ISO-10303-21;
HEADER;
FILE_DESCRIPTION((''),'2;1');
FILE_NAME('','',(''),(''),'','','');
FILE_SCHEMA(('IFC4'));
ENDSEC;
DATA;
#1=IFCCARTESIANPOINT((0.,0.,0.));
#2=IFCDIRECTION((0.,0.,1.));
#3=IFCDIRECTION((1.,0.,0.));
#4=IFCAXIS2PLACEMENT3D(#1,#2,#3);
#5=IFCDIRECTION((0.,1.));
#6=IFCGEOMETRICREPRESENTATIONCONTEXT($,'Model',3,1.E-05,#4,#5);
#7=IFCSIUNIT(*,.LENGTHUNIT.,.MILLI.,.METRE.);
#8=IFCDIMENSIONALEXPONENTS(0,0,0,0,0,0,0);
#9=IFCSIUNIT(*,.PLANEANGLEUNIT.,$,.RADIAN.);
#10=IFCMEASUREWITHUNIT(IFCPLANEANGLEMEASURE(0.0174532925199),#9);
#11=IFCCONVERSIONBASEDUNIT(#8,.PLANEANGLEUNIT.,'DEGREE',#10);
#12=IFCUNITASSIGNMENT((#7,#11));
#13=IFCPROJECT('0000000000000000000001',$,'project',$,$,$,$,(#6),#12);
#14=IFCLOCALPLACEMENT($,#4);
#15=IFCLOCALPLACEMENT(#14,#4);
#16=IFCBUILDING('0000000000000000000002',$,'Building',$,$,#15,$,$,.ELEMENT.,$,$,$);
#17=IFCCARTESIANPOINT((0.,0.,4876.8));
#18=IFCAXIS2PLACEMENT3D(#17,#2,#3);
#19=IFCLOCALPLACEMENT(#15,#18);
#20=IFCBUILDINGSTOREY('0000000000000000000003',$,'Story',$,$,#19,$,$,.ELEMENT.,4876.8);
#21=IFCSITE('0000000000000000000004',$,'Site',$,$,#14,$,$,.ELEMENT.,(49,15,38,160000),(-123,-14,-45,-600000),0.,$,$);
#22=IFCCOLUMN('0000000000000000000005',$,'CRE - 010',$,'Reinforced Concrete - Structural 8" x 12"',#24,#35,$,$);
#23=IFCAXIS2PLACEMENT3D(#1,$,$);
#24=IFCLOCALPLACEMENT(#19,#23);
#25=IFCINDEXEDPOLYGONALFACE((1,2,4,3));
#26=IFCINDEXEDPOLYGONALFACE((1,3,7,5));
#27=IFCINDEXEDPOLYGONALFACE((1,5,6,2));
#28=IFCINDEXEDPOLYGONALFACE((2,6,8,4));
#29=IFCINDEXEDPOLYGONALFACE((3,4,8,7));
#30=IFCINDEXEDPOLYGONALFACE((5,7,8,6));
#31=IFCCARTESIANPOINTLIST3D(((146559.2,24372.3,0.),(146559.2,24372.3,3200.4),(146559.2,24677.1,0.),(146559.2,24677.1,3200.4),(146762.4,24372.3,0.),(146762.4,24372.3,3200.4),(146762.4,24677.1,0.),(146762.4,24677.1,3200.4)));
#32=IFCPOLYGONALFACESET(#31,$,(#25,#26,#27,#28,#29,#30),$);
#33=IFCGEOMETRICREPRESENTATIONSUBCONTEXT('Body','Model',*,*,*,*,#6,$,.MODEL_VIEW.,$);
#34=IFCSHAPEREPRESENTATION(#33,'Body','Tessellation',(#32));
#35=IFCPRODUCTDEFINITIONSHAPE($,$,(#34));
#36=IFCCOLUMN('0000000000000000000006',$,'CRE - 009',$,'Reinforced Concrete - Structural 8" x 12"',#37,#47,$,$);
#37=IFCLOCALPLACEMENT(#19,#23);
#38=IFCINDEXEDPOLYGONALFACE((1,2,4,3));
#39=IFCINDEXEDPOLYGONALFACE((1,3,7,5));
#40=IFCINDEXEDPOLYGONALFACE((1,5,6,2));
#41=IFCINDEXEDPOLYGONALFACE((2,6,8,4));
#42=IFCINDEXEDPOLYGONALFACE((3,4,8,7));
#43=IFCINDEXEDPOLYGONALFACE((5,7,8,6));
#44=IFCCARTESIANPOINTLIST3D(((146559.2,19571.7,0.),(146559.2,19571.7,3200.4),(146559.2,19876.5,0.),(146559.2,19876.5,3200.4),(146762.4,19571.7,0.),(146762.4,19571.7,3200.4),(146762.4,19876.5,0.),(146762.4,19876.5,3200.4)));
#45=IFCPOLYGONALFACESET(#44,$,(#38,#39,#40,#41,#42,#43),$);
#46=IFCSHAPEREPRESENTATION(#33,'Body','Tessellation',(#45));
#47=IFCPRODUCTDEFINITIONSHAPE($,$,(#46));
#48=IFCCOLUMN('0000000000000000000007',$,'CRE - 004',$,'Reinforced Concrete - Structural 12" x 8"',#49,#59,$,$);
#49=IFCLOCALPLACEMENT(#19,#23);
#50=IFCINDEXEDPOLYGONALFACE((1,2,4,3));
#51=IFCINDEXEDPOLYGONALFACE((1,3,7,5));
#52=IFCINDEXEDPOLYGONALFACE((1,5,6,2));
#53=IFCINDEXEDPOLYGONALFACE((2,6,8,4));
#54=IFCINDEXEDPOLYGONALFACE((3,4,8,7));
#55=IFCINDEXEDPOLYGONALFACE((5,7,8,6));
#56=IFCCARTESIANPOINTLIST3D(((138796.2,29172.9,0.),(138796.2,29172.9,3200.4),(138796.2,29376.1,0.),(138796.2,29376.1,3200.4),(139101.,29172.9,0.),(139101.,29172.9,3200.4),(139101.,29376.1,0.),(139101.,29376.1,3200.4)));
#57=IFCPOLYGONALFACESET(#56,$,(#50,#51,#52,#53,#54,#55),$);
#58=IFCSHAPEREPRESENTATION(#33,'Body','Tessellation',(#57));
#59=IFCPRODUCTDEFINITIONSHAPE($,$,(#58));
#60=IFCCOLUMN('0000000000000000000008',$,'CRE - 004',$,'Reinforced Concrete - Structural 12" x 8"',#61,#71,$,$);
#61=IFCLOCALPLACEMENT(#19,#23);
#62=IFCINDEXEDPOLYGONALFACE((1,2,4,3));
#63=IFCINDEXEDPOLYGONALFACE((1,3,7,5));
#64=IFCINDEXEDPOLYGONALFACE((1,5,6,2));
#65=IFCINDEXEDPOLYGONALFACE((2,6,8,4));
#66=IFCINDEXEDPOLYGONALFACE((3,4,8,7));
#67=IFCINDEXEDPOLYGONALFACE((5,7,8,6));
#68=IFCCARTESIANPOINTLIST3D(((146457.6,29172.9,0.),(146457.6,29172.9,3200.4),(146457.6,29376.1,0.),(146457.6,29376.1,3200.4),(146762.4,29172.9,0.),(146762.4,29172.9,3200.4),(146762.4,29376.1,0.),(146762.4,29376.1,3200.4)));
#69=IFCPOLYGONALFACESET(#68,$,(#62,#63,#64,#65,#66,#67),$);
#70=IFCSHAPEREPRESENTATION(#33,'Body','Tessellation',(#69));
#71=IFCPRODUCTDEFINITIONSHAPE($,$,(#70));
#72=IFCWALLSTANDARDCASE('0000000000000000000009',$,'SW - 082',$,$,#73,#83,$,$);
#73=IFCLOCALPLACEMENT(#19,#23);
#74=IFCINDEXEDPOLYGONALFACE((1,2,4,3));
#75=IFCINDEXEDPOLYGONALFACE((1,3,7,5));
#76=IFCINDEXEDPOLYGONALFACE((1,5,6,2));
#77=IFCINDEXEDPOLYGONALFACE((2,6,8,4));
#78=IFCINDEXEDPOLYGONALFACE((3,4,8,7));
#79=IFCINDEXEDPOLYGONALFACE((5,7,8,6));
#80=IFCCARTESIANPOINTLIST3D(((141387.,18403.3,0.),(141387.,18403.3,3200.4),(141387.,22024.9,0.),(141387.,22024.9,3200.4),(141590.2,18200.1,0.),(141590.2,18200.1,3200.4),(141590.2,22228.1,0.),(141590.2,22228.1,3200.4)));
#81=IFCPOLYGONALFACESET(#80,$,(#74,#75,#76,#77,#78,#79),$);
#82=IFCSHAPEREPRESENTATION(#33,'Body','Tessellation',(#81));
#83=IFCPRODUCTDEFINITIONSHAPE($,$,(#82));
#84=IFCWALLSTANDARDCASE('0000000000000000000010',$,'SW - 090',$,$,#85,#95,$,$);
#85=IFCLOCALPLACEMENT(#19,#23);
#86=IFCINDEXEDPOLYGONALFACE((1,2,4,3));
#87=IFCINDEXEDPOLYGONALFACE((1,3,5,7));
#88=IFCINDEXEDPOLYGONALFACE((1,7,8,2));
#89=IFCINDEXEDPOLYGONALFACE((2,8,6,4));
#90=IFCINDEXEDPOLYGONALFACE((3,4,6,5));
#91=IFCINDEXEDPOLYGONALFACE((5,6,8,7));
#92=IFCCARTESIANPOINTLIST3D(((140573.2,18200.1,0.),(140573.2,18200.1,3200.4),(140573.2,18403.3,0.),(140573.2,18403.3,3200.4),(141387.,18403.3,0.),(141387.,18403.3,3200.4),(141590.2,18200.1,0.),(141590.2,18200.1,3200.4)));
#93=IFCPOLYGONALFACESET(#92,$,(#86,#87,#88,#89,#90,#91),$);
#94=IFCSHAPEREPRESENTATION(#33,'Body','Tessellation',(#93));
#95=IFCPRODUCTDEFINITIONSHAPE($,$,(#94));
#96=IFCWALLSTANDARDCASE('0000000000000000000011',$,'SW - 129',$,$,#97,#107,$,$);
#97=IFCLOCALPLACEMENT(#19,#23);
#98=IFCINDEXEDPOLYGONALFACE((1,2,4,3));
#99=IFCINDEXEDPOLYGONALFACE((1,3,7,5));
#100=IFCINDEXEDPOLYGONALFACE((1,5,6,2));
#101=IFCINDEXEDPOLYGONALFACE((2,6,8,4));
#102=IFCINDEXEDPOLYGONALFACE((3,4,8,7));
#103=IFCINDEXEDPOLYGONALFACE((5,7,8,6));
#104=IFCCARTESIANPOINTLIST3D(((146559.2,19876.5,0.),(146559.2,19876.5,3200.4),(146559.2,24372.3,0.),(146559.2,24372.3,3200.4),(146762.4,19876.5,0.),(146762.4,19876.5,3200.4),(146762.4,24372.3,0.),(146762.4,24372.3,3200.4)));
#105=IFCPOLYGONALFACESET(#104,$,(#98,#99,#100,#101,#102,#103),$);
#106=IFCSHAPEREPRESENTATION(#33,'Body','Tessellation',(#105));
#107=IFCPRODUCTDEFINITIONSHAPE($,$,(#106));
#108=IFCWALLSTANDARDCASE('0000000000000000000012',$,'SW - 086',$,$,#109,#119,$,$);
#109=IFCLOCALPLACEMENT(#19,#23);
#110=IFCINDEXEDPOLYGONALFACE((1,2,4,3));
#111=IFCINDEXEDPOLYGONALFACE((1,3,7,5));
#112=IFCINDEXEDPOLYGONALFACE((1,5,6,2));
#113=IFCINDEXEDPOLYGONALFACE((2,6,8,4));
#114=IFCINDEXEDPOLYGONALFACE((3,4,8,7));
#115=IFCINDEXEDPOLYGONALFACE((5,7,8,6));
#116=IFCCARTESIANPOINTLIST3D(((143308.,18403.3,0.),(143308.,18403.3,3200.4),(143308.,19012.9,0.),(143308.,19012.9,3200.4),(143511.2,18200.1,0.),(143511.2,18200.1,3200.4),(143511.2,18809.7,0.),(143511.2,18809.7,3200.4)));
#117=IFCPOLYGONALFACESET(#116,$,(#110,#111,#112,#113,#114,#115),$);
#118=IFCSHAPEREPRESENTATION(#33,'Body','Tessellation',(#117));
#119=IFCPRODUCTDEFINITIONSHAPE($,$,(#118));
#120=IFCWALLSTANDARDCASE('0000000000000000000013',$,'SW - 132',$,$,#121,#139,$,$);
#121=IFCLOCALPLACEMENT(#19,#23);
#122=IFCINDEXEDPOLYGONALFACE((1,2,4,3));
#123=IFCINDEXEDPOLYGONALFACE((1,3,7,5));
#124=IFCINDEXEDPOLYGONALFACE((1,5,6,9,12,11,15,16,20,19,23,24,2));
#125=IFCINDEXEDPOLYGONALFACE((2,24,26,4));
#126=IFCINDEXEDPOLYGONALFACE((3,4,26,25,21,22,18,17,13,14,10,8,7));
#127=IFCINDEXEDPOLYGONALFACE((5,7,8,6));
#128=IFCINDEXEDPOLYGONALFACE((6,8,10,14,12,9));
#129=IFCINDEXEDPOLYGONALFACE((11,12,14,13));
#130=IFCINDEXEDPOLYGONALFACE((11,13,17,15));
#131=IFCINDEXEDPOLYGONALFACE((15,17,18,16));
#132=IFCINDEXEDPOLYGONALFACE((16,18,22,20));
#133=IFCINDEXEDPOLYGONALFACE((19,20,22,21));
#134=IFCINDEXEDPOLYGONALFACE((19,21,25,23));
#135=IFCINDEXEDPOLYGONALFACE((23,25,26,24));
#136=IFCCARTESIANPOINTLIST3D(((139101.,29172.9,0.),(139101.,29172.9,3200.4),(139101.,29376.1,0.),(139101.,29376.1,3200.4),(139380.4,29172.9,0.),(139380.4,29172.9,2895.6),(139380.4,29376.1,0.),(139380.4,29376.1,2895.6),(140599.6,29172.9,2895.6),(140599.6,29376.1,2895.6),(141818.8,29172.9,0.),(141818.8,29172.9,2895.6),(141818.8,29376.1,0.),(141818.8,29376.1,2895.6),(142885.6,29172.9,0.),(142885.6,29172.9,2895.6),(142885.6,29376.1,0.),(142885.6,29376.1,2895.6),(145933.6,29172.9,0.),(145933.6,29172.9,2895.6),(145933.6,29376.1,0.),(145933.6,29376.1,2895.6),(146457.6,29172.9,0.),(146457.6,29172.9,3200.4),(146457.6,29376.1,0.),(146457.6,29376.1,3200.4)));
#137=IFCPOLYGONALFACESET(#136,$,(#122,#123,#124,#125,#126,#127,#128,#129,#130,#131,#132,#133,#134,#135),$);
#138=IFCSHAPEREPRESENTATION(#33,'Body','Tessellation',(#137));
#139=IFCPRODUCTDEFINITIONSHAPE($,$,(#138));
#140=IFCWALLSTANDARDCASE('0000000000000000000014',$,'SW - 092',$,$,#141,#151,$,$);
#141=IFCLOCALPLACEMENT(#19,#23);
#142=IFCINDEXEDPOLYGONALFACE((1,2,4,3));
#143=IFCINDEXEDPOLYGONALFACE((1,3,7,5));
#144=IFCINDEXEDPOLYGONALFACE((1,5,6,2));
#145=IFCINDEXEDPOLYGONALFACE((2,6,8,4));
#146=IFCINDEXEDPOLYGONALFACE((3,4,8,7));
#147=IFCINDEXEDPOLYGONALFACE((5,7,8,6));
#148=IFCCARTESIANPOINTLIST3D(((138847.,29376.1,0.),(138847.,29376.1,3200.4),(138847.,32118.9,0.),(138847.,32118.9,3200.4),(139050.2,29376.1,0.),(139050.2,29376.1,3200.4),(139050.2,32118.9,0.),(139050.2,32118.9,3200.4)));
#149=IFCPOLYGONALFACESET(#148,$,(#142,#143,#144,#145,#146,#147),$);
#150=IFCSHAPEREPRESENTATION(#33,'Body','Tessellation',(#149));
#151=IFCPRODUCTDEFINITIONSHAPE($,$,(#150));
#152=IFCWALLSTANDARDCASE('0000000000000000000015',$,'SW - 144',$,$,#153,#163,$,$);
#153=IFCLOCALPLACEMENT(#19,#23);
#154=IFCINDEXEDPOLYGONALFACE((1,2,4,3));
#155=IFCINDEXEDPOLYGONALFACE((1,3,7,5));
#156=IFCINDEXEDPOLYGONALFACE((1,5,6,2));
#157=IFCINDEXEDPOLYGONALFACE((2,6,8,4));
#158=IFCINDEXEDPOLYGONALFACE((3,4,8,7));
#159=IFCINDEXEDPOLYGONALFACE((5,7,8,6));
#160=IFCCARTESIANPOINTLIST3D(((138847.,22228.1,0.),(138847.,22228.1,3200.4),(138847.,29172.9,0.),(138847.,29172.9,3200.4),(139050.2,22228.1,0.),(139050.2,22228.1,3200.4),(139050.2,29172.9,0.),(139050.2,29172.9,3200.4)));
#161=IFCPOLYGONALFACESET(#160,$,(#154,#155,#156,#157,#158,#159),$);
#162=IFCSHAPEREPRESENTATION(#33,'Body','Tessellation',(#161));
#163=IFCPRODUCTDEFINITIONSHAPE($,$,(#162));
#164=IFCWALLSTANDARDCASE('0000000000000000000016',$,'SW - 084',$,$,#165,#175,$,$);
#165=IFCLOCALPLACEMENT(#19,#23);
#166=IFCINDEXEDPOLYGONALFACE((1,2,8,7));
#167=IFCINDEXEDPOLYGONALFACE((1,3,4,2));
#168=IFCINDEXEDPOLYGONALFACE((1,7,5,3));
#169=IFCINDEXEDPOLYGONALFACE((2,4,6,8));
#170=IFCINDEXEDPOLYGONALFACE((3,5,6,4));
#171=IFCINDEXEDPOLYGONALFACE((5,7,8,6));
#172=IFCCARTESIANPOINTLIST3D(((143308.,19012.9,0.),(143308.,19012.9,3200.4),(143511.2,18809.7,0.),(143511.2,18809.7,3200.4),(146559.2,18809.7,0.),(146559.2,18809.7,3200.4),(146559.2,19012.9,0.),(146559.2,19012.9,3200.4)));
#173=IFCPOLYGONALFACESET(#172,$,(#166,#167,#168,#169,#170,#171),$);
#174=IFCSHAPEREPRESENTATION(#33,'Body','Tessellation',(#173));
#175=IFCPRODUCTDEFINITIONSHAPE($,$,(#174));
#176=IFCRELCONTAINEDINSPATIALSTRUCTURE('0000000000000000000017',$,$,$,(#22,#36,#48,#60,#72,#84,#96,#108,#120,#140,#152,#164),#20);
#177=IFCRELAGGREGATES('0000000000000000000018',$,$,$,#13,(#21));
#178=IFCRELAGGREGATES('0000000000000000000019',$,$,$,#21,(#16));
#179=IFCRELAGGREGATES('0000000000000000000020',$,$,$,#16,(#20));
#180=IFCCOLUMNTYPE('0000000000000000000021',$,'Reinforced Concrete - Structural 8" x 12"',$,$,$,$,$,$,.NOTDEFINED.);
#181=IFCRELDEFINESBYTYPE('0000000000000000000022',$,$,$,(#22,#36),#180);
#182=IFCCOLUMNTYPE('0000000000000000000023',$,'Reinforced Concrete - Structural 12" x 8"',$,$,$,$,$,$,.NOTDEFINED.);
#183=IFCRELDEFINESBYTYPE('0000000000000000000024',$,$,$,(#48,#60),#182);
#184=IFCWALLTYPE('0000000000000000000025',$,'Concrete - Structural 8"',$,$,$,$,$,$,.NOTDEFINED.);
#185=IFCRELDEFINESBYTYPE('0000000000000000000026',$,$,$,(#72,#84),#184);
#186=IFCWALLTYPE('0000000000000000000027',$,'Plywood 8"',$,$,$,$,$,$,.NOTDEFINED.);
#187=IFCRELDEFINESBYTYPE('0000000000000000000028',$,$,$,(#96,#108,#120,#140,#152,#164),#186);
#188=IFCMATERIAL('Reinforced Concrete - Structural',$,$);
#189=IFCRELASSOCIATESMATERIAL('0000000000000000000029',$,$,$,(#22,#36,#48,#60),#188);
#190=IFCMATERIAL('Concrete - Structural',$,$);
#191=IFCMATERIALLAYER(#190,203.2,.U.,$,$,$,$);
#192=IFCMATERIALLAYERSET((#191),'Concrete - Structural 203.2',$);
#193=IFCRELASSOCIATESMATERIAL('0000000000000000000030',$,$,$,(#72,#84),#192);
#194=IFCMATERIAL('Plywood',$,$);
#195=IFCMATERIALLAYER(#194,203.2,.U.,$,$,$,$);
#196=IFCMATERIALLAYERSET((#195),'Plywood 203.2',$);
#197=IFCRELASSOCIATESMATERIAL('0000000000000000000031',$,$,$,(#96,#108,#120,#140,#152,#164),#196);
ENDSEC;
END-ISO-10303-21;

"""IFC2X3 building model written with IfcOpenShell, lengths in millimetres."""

from ifc_helpers import new_model, entity, si_unit, converted_unit, direction, frame, origin_with_axes, origin_2d_with_axis, place, context, subcontext, project, spatial, polyline, rectangle, outline, extrude, material, layer, layer_set, layer_usage, type_object, element, save


model = new_model("IFC2X3")

# Units and contexts
model_context = context("Model", 3, precision=1e-05, world=origin_with_axes(), true_north=direction((0.0, 1.0)))
body_context = subcontext(model_context, "Body", "Model", "MODEL_VIEW")
ifc_project = project(units=[si_unit("LENGTHUNIT", "METRE", prefix="MILLI"), converted_unit("PLANEANGLEUNIT", "DEGREE", entity("IfcPlaneAngleMeasure", 0.0174532925199), si_unit("PLANEANGLEUNIT", "RADIAN"), dimensions=[0, 0, 0, 0, 0, 0, 0])], contexts=[model_context])

# Site, building, storey
site_placement = place(None, origin_with_axes())
site = spatial("IfcSite", under=ifc_project, at=site_placement, Name="Site", CompositionType="ELEMENT", RefLatitude=(49, 15, 38, 160000), RefLongitude=(-123, -14, -45, -600000), RefElevation=0.0)
building_placement = place(site_placement, origin_with_axes())
building = spatial("IfcBuilding", under=site, at=building_placement, Name="Building", CompositionType="ELEMENT")
storey_placement = place(building_placement, frame((0.0, 0.0, 4876.8), z_axis=(0.0, 0.0, 1.0), x_axis=(1.0, 0.0, 0.0)))
storey = spatial("IfcBuildingStorey", under=building, at=storey_placement, Name="Story", CompositionType="ELEMENT", Elevation=4876.8)

# Columns
ifc_material_1 = material(Name="Reinforced Concrete - Structural")
column_type_1 = type_object("IfcColumnType", Name="Reinforced Concrete - Structural 8\" x 12\"", PredefinedType="NOTDEFINED")
for number, where, z_axis, x_axis, name in (
    (1, (146660.8, 24524.7, 0.0), (0.0, 0.0, 1.0), (1.0, 0.0, 0.0), "CRE - 010"),
    (2, (146660.8, 19724.1, 0.0), (0.0, 0.0, 1.0), (1.0, 0.0, 0.0), "CRE - 009"),
):
    element("IfcColumn", number, at=place(storey_placement, frame(where, z_axis=z_axis, x_axis=x_axis)), inside=storey, type_object=column_type_1, material=ifc_material_1, Name=name, ObjectType="Reinforced Concrete - Structural 8\" x 12\"", context=body_context, shape_type="SweptSolid", body=[
        extrude(rectangle(XDim=203.2, YDim=304.8, at=origin_2d_with_axis()), origin_with_axes(), (0.0, 0.0, 1.0), 3200.4),
    ])
column_type_2 = type_object("IfcColumnType", Name="Reinforced Concrete - Structural 12\" x 8\"", PredefinedType="NOTDEFINED")
for number, where, z_axis, x_axis, name in (
    (3, (138948.6, 29274.5, 0.0), (0.0, 0.0, 1.0), (1.0, 0.0, 0.0), "CRE - 004"),
    (4, (146610.0, 29274.5, 0.0), (0.0, 0.0, 1.0), (1.0, 0.0, 0.0), "CRE - 004"),
):
    element("IfcColumn", number, at=place(storey_placement, frame(where, z_axis=z_axis, x_axis=x_axis)), inside=storey, type_object=column_type_2, material=ifc_material_1, Name=name, ObjectType="Reinforced Concrete - Structural 12\" x 8\"", context=body_context, shape_type="SweptSolid", body=[
        extrude(rectangle(XDim=304.8, YDim=203.2, at=origin_2d_with_axis()), origin_with_axes(), (0.0, 0.0, 1.0), 3200.4),
    ])

# Walls
ifc_material_2 = material(Name="Concrete - Structural")
ifc_layer_1 = layer(ifc_material_2, 203.2, ventilated="UNKNOWN")
ifc_layer_set_1 = layer_set([ifc_layer_1], Name="Concrete - Structural 203.2")
ifc_layer_usage_1 = layer_usage(ifc_layer_set_1, "AXIS2", "POSITIVE", 0.0)
wall_type_1 = type_object("IfcWallType", Name="Concrete - Structural 8\"", PredefinedType="NOTDEFINED")
wall_1_placement = place(storey_placement, frame((141387.0, 22024.9, 0.0), z_axis=(0.0, 0.0, 1.0), x_axis=(0.0, -1.0, 0.0)))
element("IfcWallStandardCase", 5, at=wall_1_placement, inside=storey, type_object=wall_type_1, material=ifc_layer_usage_1, Name="SW - 082", context=body_context, shape_type="SweptSolid", body=[
    extrude(outline(polyline([(0.0, 0.0), (3621.6, 0.0), (3824.8, 203.2), (-203.2, 203.2), (0.0, 0.0)])), origin_with_axes(), (0.0, 0.0, 1.0), 3200.4),
])
ifc_layer_usage_2 = layer_usage(ifc_layer_set_1, "AXIS2", "POSITIVE", 0.0)
wall_2_placement = place(storey_placement, frame((141387.0, 18403.3, 0.0), z_axis=(0.0, 0.0, 1.0), x_axis=(-1.0, 0.0, 0.0)))
element("IfcWallStandardCase", 6, at=wall_2_placement, inside=storey, type_object=wall_type_1, material=ifc_layer_usage_2, Name="SW - 090", context=body_context, shape_type="SweptSolid", body=[
    extrude(outline(polyline([(0.0, 0.0), (813.8, 0.0), (813.8, 203.2), (-203.2, 203.2), (0.0, 0.0)])), origin_with_axes(), (0.0, 0.0, 1.0), 3200.4),
])

# Shared definitions
ifc_material_3 = material(Name="Plywood")
ifc_layer_2 = layer(ifc_material_3, 203.2, ventilated="UNKNOWN")
ifc_layer_set_2 = layer_set([ifc_layer_2], Name="Plywood 203.2")
wall_type_2 = type_object("IfcWallType", Name="Plywood 8\"", PredefinedType="NOTDEFINED")

# Walls
ifc_layer_usage_3 = layer_usage(ifc_layer_set_2, "AXIS2", "POSITIVE", 0.0)
wall_3_placement = place(storey_placement, frame((146762.4, 19876.5, 0.0), z_axis=(0.0, 0.0, 1.0), x_axis=(0.0, 1.0, 0.0)))
element("IfcWallStandardCase", 7, at=wall_3_placement, inside=storey, type_object=wall_type_2, material=ifc_layer_usage_3, Name="SW - 129", context=body_context, shape_type="SweptSolid", body=[
    extrude(outline(polyline([(0.0, 0.0), (4495.8, 0.0), (4495.8, 203.2), (0.0, 203.2), (0.0, 0.0)])), origin_with_axes(), (0.0, 0.0, 1.0), 3200.4),
])
ifc_layer_usage_4 = layer_usage(ifc_layer_set_2, "AXIS2", "NEGATIVE", 0.0)
wall_4_placement = place(storey_placement, frame((143511.2, 19012.9, 0.0), z_axis=(0.0, 0.0, 1.0), x_axis=(0.0, -1.0, 0.0)))
element("IfcWallStandardCase", 8, at=wall_4_placement, inside=storey, type_object=wall_type_2, material=ifc_layer_usage_4, Name="SW - 086", context=body_context, shape_type="SweptSolid", body=[
    extrude(outline(polyline([(0.0, -203.2), (609.6, -203.2), (812.8, 0.0), (203.2, 0.0), (0.0, -203.2)])), origin_with_axes(), (0.0, 0.0, 1.0), 3200.4),
])

# Wall, openings
ifc_layer_usage_5 = layer_usage(ifc_layer_set_2, "AXIS2", "POSITIVE", 0.0)
wall_5_placement = place(storey_placement, frame((146457.6, 29376.1, 0.0), z_axis=(0.0, 0.0, 1.0), x_axis=(-1.0, 0.0, 0.0)))
wall_5 = element("IfcWallStandardCase", 9, at=wall_5_placement, inside=storey, type_object=wall_type_2, material=ifc_layer_usage_5, Name="SW - 132", context=body_context, shape_type="SweptSolid", body=[
    extrude(outline(polyline([(0.0, 0.0), (7356.6, 0.0), (7356.6, 203.2), (0.0, 203.2), (0.0, 0.0)])), origin_with_axes(), (0.0, 0.0, 1.0), 3200.4),
])
opening_1_placement = place(wall_5_placement, frame((5248.4, 0.0, 0.0), z_axis=(0.0, 0.0, 1.0), x_axis=(1.0, 0.0, 0.0)))
element("IfcOpeningElement", 10, at=opening_1_placement, cuts=wall_5, context=body_context, shape_type="SweptSolid", body=[
    extrude(rectangle(XDim=1219.2, YDim=2895.6, at=origin_2d_with_axis()), frame((0.0, 406.4, 1447.8), z_axis=(0.0, 1.0, 0.0), x_axis=(1.0, 0.0, 0.0)), (0.0, 0.0, -1.0), 609.6),
])
opening_2_placement = place(wall_5_placement, frame((6467.6, 0.0, 0.0), z_axis=(0.0, 0.0, 1.0), x_axis=(1.0, 0.0, 0.0)))
element("IfcOpeningElement", 11, at=opening_2_placement, cuts=wall_5, context=body_context, shape_type="SweptSolid", body=[
    extrude(rectangle(XDim=1219.2, YDim=2895.6, at=origin_2d_with_axis()), frame((0.0, 406.4, 1447.8), z_axis=(0.0, 1.0, 0.0), x_axis=(1.0, 0.0, 0.0)), (0.0, 0.0, -1.0), 609.6),
])
opening_3_placement = place(wall_5_placement, frame((2048.0, 0.0, 0.0), z_axis=(0.0, 0.0, 1.0), x_axis=(1.0, 0.0, 0.0)))
element("IfcOpeningElement", 12, at=opening_3_placement, cuts=wall_5, context=body_context, shape_type="SweptSolid", body=[
    extrude(rectangle(XDim=3048.0, YDim=2895.6, at=origin_2d_with_axis()), frame((0.0, 406.4, 1447.8), z_axis=(0.0, -1.0, 0.0), x_axis=(-1.0, 0.0, 0.0)), (0.0, 0.0, 1.0), 609.6),
])

# Walls
ifc_layer_usage_6 = layer_usage(ifc_layer_set_2, "AXIS2", "POSITIVE", 0.0)
wall_6_placement = place(storey_placement, frame((138847.0, 32118.9, 0.0), z_axis=(0.0, 0.0, 1.0), x_axis=(0.0, -1.0, 0.0)))
element("IfcWallStandardCase", 13, at=wall_6_placement, inside=storey, type_object=wall_type_2, material=ifc_layer_usage_6, Name="SW - 092", context=body_context, shape_type="SweptSolid", body=[
    extrude(outline(polyline([(0.0, 0.0), (2742.9, 0.0), (2742.9, 203.2), (0.0, 203.2), (0.0, 0.0)])), origin_with_axes(), (0.0, 0.0, 1.0), 3200.4),
])
ifc_layer_usage_7 = layer_usage(ifc_layer_set_2, "AXIS2", "POSITIVE", -203.2)
wall_7_placement = place(storey_placement, frame((139050.2, 29172.9, 0.0), z_axis=(0.0, 0.0, 1.0), x_axis=(0.0, -1.0, 0.0)))
element("IfcWallStandardCase", 14, at=wall_7_placement, inside=storey, type_object=wall_type_2, material=ifc_layer_usage_7, Name="SW - 144", context=body_context, shape_type="SweptSolid", body=[
    extrude(outline(polyline([(0.0, -203.2), (6944.8, -203.2), (6944.8, 0.0), (0.0, 0.0), (0.0, -203.2)])), origin_with_axes(), (0.0, 0.0, 1.0), 3200.4),
])
ifc_layer_usage_8 = layer_usage(ifc_layer_set_2, "AXIS2", "POSITIVE", 0.0)
wall_8_placement = place(storey_placement, frame((146762.4, 19012.9, 0.0), z_axis=(0.0, 0.0, 1.0), x_axis=(-1.0, 0.0, 0.0)))
element("IfcWallStandardCase", 15, at=wall_8_placement, inside=storey, type_object=wall_type_2, material=ifc_layer_usage_8, Name="SW - 084", context=body_context, shape_type="SweptSolid", body=[
    extrude(outline(polyline([(203.2, 0.0), (3454.4, 0.0), (3251.2, 203.2), (203.2, 203.2), (203.2, 0.0)])), origin_with_axes(), (0.0, 0.0, 1.0), 3200.4),
])

save(model, "model.ifc")
